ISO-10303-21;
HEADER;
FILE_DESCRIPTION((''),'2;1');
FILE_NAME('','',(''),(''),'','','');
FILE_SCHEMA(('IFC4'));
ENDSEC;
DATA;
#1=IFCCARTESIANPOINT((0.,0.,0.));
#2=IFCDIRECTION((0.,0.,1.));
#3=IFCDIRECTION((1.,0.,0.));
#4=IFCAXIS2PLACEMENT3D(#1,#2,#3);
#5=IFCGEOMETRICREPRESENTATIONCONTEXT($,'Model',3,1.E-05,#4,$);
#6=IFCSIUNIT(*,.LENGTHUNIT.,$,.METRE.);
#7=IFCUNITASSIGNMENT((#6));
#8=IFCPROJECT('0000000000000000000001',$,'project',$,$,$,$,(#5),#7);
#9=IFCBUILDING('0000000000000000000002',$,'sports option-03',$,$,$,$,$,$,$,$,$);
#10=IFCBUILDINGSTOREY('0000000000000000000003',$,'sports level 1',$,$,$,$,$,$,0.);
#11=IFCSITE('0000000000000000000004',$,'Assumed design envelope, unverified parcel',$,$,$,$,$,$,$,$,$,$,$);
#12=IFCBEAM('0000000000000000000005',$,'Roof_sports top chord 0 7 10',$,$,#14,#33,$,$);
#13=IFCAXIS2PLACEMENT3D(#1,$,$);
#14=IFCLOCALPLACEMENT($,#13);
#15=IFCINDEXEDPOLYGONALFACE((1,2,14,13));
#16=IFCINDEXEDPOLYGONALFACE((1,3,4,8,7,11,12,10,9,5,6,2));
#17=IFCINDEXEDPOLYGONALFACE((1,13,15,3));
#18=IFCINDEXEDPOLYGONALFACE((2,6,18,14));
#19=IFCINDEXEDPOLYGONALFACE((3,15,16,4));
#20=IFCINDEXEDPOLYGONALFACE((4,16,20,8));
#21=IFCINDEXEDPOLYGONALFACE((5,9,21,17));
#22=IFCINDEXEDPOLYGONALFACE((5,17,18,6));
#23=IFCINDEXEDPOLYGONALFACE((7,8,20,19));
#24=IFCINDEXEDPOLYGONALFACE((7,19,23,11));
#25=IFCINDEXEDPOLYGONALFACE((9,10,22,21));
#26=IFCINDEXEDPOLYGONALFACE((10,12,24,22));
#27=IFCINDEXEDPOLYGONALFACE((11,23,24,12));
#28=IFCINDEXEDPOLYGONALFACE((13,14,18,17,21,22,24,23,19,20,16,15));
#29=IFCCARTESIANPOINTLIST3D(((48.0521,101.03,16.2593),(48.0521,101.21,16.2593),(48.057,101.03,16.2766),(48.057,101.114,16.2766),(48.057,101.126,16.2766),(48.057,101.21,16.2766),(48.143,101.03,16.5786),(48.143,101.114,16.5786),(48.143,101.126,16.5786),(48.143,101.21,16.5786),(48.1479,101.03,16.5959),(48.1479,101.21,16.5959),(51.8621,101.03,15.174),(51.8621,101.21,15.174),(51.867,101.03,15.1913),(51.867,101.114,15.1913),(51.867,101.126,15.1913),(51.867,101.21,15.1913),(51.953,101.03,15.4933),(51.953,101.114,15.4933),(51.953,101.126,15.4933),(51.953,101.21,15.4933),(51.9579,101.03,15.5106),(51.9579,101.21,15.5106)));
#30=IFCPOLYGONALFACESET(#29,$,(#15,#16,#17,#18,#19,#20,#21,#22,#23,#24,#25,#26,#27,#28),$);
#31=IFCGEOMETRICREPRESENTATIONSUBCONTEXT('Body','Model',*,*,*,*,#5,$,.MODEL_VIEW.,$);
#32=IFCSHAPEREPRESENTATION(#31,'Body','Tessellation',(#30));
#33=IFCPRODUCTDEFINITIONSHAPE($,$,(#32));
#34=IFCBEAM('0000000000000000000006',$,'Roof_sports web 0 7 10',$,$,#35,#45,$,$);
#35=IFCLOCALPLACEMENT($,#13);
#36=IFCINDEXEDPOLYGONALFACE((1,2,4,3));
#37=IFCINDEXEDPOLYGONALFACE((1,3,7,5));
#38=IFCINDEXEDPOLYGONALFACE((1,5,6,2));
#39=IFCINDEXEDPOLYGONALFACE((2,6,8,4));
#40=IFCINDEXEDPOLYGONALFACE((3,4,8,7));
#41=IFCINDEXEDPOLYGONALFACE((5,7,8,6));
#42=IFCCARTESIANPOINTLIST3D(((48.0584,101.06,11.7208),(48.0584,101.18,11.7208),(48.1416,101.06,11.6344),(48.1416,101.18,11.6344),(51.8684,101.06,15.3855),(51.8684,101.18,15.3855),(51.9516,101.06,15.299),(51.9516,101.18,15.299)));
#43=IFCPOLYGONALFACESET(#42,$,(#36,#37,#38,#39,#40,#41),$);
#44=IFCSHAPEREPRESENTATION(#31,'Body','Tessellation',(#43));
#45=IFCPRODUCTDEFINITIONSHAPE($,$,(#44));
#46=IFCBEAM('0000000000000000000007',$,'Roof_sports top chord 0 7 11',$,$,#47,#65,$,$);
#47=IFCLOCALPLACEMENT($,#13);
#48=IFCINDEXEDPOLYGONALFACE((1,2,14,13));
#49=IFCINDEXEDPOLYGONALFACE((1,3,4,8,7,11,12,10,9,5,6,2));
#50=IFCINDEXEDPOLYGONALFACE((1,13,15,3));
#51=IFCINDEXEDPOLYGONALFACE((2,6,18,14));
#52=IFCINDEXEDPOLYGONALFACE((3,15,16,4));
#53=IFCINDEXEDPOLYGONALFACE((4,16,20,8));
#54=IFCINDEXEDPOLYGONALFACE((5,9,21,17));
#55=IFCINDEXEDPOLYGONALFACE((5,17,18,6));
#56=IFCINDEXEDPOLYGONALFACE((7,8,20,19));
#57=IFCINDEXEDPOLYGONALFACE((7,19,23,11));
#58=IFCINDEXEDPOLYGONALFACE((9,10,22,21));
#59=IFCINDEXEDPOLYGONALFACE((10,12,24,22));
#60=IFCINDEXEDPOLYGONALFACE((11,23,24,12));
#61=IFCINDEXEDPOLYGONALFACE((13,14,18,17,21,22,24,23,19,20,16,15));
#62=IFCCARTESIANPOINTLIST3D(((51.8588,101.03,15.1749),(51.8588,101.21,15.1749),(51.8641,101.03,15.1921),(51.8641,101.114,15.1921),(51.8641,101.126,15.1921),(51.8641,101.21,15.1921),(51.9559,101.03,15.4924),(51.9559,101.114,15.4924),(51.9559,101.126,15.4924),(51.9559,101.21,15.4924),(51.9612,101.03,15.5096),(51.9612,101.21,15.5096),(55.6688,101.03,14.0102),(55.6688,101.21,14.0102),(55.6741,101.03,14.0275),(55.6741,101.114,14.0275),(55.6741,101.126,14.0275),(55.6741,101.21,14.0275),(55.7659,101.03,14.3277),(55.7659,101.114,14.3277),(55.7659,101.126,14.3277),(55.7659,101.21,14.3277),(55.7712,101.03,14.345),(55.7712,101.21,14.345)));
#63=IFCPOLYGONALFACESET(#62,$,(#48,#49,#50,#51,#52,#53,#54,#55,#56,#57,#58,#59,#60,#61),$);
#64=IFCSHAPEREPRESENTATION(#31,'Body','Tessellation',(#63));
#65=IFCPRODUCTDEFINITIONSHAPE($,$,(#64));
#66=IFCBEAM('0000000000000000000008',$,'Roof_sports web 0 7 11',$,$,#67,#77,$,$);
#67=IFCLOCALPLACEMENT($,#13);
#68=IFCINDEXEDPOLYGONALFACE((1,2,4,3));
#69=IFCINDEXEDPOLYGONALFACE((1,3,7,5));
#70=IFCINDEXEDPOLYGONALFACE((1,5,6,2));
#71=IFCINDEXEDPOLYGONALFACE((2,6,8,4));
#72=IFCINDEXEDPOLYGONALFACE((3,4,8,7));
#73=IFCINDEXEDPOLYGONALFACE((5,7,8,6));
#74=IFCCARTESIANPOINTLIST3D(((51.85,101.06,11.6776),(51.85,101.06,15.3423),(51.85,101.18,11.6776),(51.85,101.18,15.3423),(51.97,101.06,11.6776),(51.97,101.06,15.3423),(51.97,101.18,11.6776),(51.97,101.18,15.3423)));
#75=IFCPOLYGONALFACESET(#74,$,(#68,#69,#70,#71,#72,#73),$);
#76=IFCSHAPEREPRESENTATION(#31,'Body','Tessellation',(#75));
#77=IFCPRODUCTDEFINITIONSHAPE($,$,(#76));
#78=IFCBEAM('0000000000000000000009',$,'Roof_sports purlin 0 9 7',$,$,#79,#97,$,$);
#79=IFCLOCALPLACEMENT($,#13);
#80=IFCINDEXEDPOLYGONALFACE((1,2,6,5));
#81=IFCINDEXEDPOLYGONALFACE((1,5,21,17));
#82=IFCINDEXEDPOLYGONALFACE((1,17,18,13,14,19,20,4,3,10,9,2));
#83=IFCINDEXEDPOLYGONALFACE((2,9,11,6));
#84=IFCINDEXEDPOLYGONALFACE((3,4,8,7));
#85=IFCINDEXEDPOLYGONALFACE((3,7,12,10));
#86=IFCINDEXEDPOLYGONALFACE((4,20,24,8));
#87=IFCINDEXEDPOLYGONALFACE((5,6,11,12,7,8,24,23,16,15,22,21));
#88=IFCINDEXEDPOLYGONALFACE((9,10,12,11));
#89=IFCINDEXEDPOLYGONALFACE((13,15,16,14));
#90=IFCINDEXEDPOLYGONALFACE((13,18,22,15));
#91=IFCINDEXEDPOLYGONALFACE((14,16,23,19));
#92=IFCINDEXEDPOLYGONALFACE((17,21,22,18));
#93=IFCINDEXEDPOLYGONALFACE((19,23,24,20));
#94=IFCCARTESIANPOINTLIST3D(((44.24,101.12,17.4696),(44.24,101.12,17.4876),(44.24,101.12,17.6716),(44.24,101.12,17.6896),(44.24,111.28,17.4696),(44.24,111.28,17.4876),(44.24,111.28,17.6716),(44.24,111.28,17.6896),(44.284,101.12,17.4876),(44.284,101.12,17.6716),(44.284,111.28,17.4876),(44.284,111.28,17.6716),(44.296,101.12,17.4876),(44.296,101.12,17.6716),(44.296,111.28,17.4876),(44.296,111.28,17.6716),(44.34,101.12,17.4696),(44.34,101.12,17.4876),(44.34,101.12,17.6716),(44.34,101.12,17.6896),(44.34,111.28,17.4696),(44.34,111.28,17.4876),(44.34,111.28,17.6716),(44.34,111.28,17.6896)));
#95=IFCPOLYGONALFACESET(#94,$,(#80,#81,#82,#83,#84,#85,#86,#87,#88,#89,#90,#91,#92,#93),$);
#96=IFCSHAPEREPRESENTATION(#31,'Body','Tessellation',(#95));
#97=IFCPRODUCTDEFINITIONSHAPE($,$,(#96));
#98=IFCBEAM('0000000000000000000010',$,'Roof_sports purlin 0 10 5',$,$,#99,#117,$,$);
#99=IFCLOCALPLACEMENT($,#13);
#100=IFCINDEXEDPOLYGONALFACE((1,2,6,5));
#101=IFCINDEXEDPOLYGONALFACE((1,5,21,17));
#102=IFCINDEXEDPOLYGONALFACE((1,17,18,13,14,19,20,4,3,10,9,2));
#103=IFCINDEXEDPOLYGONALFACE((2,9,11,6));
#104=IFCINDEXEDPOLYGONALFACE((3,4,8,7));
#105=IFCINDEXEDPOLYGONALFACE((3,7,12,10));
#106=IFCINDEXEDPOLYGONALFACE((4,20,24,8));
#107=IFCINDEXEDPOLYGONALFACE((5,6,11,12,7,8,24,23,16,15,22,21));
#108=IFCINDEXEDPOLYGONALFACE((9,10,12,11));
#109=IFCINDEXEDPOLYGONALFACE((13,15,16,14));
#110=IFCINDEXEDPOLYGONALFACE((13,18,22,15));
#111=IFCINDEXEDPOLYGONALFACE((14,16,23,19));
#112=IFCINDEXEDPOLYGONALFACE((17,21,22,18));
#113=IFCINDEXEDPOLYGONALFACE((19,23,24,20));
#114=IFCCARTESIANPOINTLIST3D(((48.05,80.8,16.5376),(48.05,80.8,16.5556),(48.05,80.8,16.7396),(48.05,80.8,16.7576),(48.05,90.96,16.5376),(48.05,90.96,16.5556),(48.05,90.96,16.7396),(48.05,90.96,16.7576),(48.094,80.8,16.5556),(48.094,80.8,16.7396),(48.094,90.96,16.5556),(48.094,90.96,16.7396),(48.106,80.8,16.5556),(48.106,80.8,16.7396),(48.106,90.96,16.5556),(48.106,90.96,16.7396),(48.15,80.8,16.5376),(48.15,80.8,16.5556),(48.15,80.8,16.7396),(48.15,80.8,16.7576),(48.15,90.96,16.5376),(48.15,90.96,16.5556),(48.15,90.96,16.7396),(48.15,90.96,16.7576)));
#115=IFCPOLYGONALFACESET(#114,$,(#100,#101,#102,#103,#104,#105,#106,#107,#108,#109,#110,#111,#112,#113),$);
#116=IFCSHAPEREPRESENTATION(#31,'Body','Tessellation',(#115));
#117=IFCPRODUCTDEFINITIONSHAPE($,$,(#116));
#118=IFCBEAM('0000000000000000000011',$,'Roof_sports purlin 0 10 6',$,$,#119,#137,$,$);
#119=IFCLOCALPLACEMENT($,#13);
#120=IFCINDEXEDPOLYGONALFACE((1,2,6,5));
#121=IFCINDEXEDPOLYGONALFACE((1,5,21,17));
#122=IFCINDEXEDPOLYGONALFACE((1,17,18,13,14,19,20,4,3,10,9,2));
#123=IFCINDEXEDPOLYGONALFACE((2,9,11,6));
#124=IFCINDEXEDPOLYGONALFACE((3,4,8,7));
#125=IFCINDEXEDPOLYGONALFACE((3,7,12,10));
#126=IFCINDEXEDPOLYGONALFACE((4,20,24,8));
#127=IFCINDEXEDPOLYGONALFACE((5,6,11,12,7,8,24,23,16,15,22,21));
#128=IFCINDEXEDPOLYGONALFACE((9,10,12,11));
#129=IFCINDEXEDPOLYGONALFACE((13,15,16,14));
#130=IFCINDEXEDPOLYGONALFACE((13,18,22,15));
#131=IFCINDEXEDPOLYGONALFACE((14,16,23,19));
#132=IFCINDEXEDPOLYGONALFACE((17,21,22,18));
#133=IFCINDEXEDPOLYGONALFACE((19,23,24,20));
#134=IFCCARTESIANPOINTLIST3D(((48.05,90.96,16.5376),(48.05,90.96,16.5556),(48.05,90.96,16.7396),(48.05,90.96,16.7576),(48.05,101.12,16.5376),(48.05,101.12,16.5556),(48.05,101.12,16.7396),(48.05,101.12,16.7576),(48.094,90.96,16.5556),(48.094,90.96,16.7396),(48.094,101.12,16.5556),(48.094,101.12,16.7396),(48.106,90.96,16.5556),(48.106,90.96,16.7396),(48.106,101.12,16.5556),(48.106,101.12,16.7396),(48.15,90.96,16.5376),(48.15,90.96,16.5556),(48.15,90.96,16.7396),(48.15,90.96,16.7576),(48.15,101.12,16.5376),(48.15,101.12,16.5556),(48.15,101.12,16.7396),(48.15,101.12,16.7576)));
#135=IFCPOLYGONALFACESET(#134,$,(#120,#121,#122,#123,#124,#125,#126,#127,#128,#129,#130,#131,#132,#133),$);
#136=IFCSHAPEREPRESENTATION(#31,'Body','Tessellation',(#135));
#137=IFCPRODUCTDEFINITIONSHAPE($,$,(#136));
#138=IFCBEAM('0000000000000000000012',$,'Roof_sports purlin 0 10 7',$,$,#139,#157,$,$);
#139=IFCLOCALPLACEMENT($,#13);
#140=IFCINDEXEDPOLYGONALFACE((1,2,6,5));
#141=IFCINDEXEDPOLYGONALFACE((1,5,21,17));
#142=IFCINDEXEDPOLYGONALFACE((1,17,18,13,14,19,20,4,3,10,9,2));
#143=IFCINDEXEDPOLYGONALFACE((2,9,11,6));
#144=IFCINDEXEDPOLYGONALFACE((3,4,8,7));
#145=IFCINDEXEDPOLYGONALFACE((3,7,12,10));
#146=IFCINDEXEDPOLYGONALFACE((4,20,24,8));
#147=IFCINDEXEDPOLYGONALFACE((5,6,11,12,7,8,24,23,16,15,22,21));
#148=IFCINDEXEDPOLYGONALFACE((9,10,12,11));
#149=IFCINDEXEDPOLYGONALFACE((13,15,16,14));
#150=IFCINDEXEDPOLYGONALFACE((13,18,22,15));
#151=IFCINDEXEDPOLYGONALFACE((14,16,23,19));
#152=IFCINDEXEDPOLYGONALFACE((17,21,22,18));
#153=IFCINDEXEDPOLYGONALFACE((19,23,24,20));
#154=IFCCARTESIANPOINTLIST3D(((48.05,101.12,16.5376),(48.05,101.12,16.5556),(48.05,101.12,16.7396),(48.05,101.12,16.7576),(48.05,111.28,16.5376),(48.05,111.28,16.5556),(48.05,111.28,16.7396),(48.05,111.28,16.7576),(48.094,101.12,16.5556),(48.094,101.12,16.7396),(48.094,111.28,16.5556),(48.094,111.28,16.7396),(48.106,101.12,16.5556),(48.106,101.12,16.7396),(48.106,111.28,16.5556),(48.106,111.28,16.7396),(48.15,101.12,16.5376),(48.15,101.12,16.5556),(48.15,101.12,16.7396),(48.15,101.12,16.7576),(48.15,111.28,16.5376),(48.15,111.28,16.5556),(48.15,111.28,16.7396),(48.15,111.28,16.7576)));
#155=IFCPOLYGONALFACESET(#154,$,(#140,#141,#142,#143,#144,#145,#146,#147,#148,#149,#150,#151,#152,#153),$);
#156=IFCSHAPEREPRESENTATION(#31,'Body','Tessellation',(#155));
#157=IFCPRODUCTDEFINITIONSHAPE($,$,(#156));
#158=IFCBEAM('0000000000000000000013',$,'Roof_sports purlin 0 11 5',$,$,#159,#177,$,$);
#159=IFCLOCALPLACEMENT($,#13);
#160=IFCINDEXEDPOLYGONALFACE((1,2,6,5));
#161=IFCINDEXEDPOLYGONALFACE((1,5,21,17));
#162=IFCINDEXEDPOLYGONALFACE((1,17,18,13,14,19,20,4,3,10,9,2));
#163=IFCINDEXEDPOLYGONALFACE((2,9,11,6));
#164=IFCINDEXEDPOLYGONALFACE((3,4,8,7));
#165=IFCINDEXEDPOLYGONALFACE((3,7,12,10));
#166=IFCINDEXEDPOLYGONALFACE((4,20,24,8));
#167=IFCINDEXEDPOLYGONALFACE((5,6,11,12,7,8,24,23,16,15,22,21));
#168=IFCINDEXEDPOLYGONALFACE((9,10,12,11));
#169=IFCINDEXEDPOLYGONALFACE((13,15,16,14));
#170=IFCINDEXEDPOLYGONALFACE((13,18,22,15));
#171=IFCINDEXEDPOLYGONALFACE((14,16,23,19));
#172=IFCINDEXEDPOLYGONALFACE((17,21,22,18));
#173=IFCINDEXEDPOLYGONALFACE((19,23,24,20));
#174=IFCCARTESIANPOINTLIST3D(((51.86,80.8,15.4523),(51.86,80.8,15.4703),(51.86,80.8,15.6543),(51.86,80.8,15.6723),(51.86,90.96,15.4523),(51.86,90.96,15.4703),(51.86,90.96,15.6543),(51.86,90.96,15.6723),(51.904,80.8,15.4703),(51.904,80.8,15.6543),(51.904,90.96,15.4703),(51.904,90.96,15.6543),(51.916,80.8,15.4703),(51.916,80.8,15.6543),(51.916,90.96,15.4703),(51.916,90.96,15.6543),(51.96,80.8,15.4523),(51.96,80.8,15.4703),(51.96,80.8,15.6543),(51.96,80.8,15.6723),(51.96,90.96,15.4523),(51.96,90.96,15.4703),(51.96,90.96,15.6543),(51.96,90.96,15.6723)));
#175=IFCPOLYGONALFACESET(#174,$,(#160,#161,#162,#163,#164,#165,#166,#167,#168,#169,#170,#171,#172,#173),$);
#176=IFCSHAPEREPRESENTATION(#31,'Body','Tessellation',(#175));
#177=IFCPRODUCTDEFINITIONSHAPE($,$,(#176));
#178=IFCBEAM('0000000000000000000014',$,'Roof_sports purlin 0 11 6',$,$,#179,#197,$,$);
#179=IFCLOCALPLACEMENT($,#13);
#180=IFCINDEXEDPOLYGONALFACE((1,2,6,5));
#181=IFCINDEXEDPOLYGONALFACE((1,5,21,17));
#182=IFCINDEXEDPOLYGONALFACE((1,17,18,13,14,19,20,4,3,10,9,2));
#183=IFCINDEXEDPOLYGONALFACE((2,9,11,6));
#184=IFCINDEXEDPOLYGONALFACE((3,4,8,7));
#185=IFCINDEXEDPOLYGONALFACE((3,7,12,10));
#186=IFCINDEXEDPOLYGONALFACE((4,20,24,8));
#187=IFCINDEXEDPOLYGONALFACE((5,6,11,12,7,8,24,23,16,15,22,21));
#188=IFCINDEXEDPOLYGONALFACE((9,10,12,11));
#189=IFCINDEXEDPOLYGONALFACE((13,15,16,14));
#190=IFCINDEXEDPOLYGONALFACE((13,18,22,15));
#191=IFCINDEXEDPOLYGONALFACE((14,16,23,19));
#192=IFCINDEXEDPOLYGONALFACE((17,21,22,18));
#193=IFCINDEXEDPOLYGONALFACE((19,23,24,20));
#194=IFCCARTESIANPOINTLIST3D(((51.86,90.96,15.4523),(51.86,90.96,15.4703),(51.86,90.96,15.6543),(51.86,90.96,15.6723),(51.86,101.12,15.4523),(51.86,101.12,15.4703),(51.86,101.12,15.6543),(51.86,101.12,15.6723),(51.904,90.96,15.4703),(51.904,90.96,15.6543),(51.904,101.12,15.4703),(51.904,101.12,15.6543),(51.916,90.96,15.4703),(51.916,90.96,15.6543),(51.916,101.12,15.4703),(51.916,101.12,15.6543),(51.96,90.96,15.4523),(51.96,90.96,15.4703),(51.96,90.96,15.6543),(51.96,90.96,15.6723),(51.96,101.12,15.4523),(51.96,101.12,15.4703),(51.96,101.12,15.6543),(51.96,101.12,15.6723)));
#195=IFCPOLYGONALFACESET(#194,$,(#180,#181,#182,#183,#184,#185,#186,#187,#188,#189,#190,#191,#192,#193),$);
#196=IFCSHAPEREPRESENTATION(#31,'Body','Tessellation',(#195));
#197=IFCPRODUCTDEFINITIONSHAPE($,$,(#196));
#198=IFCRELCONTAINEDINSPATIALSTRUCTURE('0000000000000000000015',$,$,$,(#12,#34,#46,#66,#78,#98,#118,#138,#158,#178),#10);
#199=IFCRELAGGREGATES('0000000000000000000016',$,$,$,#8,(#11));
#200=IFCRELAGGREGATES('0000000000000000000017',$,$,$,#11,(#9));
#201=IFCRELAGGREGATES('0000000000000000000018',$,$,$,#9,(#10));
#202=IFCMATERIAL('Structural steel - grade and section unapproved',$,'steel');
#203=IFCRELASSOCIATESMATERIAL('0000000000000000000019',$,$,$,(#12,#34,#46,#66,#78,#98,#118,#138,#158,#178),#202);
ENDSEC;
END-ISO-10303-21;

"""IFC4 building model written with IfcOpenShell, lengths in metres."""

from ifc_helpers import new_model, si_unit, frame, origin_with_axes, place, context, subcontext, project, spatial, rectangle, i_section, extrude, material, element, save


model = new_model("IFC4")

# Units and contexts
model_context = context("Model", 3, precision=1e-05, world=origin_with_axes())
body_context = subcontext(model_context, "Body", "Model", "MODEL_VIEW")
ifc_project = project(units=[si_unit("LENGTHUNIT", "METRE")], contexts=[model_context])

# Site, building, storey
site = spatial("IfcSite", under=ifc_project, Name="Assumed design envelope, unverified parcel")
building = spatial("IfcBuilding", under=site, Name="sports option-03")
storey = spatial("IfcBuildingStorey", under=building, Name="sports level 1", Elevation=0.0)

# Shared definitions
ifc_material = material(Name="Structural steel - grade and section unapproved", Category="steel")

# Beams
beam_1_placement = place(None, frame((48.1, 101.12, 16.4276), z_axis=(0.961741, 0.0, -0.273961), x_axis=(0.0, 1.0, 0.0)))
element("IfcBeam", 1, at=beam_1_placement, inside=storey, material=ifc_material, Name="Roof_sports top chord 0 7 10", context=body_context, shape_type="SweptSolid", body=[
    extrude(i_section(OverallWidth=0.18, OverallDepth=0.35, WebThickness=0.012, FlangeThickness=0.018, FilletRadius=0.0), origin_with_axes(), (0.0, 0.0, 1.0), 3.9616),
])
beam_2_placement = place(None, frame((48.1, 101.12, 11.6776), z_axis=(0.720717, 0.0, 0.693229), x_axis=(0.0, 1.0, 0.0)))
element("IfcBeam", 2, at=beam_2_placement, inside=storey, material=ifc_material, Name="Roof_sports web 0 7 10", context=body_context, shape_type="SweptSolid", body=[
    extrude(rectangle(XDim=0.12, YDim=0.12), origin_with_axes(), (0.0, 0.0, 1.0), 5.2864),
])
beam_3_placement = place(None, frame((51.91, 101.12, 15.3423), z_axis=(0.956315, 0.0, -0.292337), x_axis=(0.0, 1.0, 0.0)))
element("IfcBeam", 3, at=beam_3_placement, inside=storey, material=ifc_material, Name="Roof_sports top chord 0 7 11", context=body_context, shape_type="SweptSolid", body=[
    extrude(i_section(OverallWidth=0.18, OverallDepth=0.35, WebThickness=0.012, FlangeThickness=0.018, FilletRadius=0.0), origin_with_axes(), (0.0, 0.0, 1.0), 3.984),
])
beam_4_placement = place(None, frame((51.91, 101.12, 11.6776), z_axis=(0.0, 0.0, 1.0), x_axis=(-1.0, 0.0, 0.0)))
element("IfcBeam", 4, at=beam_4_placement, inside=storey, material=ifc_material, Name="Roof_sports web 0 7 11", context=body_context, shape_type="SweptSolid", body=[
    extrude(rectangle(XDim=0.12, YDim=0.12), origin_with_axes(), (0.0, 0.0, 1.0), 3.6647),
])
for number, where, z_axis, x_axis, name in (
    (5, (44.29, 101.12, 17.5796), (0.0, 1.0, 0.0), (-1.0, 0.0, 0.0), "Roof_sports purlin 0 9 7"),
    (6, (48.1, 80.8, 16.6476), (0.0, 1.0, 0.0), (-1.0, 0.0, 0.0), "Roof_sports purlin 0 10 5"),
):
    element("IfcBeam", number, at=place(None, frame(where, z_axis=z_axis, x_axis=x_axis)), inside=storey, material=ifc_material, Name=name, context=body_context, shape_type="SweptSolid", body=[
        extrude(i_section(OverallWidth=0.1, OverallDepth=0.22, WebThickness=0.012, FlangeThickness=0.018, FilletRadius=0.0), origin_with_axes(), (0.0, 0.0, 1.0), 10.16),
    ])
beam_5_placement = place(None, frame((48.1, 90.96, 16.6476), z_axis=(0.0, 1.0, 0.0), x_axis=(-1.0, 0.0, 0.0)))
element("IfcBeam", 7, at=beam_5_placement, inside=storey, material=ifc_material, Name="Roof_sports purlin 0 10 6", context=body_context, shape_type="SweptSolid", body=[
    extrude(i_section(OverallWidth=0.1, OverallDepth=0.22, WebThickness=0.012, FlangeThickness=0.018, FilletRadius=0.0), origin_with_axes(), (0.0, 0.0, 1.0), 10.16),
])
for number, where, z_axis, x_axis, name in (
    (8, (48.1, 101.12, 16.6476), (0.0, 1.0, 0.0), (-1.0, 0.0, 0.0), "Roof_sports purlin 0 10 7"),
    (9, (51.91, 80.8, 15.5623), (0.0, 1.0, 0.0), (-1.0, 0.0, 0.0), "Roof_sports purlin 0 11 5"),
):
    element("IfcBeam", number, at=place(None, frame(where, z_axis=z_axis, x_axis=x_axis)), inside=storey, material=ifc_material, Name=name, context=body_context, shape_type="SweptSolid", body=[
        extrude(i_section(OverallWidth=0.1, OverallDepth=0.22, WebThickness=0.012, FlangeThickness=0.018, FilletRadius=0.0), origin_with_axes(), (0.0, 0.0, 1.0), 10.16),
    ])
beam_6_placement = place(None, frame((51.91, 90.96, 15.5623), z_axis=(0.0, 1.0, 0.0), x_axis=(-1.0, 0.0, 0.0)))
element("IfcBeam", 10, at=beam_6_placement, inside=storey, material=ifc_material, Name="Roof_sports purlin 0 11 6", context=body_context, shape_type="SweptSolid", body=[
    extrude(i_section(OverallWidth=0.1, OverallDepth=0.22, WebThickness=0.012, FlangeThickness=0.018, FilletRadius=0.0), origin_with_axes(), (0.0, 0.0, 1.0), 10.16),
])

save(model, "model.ifc")
